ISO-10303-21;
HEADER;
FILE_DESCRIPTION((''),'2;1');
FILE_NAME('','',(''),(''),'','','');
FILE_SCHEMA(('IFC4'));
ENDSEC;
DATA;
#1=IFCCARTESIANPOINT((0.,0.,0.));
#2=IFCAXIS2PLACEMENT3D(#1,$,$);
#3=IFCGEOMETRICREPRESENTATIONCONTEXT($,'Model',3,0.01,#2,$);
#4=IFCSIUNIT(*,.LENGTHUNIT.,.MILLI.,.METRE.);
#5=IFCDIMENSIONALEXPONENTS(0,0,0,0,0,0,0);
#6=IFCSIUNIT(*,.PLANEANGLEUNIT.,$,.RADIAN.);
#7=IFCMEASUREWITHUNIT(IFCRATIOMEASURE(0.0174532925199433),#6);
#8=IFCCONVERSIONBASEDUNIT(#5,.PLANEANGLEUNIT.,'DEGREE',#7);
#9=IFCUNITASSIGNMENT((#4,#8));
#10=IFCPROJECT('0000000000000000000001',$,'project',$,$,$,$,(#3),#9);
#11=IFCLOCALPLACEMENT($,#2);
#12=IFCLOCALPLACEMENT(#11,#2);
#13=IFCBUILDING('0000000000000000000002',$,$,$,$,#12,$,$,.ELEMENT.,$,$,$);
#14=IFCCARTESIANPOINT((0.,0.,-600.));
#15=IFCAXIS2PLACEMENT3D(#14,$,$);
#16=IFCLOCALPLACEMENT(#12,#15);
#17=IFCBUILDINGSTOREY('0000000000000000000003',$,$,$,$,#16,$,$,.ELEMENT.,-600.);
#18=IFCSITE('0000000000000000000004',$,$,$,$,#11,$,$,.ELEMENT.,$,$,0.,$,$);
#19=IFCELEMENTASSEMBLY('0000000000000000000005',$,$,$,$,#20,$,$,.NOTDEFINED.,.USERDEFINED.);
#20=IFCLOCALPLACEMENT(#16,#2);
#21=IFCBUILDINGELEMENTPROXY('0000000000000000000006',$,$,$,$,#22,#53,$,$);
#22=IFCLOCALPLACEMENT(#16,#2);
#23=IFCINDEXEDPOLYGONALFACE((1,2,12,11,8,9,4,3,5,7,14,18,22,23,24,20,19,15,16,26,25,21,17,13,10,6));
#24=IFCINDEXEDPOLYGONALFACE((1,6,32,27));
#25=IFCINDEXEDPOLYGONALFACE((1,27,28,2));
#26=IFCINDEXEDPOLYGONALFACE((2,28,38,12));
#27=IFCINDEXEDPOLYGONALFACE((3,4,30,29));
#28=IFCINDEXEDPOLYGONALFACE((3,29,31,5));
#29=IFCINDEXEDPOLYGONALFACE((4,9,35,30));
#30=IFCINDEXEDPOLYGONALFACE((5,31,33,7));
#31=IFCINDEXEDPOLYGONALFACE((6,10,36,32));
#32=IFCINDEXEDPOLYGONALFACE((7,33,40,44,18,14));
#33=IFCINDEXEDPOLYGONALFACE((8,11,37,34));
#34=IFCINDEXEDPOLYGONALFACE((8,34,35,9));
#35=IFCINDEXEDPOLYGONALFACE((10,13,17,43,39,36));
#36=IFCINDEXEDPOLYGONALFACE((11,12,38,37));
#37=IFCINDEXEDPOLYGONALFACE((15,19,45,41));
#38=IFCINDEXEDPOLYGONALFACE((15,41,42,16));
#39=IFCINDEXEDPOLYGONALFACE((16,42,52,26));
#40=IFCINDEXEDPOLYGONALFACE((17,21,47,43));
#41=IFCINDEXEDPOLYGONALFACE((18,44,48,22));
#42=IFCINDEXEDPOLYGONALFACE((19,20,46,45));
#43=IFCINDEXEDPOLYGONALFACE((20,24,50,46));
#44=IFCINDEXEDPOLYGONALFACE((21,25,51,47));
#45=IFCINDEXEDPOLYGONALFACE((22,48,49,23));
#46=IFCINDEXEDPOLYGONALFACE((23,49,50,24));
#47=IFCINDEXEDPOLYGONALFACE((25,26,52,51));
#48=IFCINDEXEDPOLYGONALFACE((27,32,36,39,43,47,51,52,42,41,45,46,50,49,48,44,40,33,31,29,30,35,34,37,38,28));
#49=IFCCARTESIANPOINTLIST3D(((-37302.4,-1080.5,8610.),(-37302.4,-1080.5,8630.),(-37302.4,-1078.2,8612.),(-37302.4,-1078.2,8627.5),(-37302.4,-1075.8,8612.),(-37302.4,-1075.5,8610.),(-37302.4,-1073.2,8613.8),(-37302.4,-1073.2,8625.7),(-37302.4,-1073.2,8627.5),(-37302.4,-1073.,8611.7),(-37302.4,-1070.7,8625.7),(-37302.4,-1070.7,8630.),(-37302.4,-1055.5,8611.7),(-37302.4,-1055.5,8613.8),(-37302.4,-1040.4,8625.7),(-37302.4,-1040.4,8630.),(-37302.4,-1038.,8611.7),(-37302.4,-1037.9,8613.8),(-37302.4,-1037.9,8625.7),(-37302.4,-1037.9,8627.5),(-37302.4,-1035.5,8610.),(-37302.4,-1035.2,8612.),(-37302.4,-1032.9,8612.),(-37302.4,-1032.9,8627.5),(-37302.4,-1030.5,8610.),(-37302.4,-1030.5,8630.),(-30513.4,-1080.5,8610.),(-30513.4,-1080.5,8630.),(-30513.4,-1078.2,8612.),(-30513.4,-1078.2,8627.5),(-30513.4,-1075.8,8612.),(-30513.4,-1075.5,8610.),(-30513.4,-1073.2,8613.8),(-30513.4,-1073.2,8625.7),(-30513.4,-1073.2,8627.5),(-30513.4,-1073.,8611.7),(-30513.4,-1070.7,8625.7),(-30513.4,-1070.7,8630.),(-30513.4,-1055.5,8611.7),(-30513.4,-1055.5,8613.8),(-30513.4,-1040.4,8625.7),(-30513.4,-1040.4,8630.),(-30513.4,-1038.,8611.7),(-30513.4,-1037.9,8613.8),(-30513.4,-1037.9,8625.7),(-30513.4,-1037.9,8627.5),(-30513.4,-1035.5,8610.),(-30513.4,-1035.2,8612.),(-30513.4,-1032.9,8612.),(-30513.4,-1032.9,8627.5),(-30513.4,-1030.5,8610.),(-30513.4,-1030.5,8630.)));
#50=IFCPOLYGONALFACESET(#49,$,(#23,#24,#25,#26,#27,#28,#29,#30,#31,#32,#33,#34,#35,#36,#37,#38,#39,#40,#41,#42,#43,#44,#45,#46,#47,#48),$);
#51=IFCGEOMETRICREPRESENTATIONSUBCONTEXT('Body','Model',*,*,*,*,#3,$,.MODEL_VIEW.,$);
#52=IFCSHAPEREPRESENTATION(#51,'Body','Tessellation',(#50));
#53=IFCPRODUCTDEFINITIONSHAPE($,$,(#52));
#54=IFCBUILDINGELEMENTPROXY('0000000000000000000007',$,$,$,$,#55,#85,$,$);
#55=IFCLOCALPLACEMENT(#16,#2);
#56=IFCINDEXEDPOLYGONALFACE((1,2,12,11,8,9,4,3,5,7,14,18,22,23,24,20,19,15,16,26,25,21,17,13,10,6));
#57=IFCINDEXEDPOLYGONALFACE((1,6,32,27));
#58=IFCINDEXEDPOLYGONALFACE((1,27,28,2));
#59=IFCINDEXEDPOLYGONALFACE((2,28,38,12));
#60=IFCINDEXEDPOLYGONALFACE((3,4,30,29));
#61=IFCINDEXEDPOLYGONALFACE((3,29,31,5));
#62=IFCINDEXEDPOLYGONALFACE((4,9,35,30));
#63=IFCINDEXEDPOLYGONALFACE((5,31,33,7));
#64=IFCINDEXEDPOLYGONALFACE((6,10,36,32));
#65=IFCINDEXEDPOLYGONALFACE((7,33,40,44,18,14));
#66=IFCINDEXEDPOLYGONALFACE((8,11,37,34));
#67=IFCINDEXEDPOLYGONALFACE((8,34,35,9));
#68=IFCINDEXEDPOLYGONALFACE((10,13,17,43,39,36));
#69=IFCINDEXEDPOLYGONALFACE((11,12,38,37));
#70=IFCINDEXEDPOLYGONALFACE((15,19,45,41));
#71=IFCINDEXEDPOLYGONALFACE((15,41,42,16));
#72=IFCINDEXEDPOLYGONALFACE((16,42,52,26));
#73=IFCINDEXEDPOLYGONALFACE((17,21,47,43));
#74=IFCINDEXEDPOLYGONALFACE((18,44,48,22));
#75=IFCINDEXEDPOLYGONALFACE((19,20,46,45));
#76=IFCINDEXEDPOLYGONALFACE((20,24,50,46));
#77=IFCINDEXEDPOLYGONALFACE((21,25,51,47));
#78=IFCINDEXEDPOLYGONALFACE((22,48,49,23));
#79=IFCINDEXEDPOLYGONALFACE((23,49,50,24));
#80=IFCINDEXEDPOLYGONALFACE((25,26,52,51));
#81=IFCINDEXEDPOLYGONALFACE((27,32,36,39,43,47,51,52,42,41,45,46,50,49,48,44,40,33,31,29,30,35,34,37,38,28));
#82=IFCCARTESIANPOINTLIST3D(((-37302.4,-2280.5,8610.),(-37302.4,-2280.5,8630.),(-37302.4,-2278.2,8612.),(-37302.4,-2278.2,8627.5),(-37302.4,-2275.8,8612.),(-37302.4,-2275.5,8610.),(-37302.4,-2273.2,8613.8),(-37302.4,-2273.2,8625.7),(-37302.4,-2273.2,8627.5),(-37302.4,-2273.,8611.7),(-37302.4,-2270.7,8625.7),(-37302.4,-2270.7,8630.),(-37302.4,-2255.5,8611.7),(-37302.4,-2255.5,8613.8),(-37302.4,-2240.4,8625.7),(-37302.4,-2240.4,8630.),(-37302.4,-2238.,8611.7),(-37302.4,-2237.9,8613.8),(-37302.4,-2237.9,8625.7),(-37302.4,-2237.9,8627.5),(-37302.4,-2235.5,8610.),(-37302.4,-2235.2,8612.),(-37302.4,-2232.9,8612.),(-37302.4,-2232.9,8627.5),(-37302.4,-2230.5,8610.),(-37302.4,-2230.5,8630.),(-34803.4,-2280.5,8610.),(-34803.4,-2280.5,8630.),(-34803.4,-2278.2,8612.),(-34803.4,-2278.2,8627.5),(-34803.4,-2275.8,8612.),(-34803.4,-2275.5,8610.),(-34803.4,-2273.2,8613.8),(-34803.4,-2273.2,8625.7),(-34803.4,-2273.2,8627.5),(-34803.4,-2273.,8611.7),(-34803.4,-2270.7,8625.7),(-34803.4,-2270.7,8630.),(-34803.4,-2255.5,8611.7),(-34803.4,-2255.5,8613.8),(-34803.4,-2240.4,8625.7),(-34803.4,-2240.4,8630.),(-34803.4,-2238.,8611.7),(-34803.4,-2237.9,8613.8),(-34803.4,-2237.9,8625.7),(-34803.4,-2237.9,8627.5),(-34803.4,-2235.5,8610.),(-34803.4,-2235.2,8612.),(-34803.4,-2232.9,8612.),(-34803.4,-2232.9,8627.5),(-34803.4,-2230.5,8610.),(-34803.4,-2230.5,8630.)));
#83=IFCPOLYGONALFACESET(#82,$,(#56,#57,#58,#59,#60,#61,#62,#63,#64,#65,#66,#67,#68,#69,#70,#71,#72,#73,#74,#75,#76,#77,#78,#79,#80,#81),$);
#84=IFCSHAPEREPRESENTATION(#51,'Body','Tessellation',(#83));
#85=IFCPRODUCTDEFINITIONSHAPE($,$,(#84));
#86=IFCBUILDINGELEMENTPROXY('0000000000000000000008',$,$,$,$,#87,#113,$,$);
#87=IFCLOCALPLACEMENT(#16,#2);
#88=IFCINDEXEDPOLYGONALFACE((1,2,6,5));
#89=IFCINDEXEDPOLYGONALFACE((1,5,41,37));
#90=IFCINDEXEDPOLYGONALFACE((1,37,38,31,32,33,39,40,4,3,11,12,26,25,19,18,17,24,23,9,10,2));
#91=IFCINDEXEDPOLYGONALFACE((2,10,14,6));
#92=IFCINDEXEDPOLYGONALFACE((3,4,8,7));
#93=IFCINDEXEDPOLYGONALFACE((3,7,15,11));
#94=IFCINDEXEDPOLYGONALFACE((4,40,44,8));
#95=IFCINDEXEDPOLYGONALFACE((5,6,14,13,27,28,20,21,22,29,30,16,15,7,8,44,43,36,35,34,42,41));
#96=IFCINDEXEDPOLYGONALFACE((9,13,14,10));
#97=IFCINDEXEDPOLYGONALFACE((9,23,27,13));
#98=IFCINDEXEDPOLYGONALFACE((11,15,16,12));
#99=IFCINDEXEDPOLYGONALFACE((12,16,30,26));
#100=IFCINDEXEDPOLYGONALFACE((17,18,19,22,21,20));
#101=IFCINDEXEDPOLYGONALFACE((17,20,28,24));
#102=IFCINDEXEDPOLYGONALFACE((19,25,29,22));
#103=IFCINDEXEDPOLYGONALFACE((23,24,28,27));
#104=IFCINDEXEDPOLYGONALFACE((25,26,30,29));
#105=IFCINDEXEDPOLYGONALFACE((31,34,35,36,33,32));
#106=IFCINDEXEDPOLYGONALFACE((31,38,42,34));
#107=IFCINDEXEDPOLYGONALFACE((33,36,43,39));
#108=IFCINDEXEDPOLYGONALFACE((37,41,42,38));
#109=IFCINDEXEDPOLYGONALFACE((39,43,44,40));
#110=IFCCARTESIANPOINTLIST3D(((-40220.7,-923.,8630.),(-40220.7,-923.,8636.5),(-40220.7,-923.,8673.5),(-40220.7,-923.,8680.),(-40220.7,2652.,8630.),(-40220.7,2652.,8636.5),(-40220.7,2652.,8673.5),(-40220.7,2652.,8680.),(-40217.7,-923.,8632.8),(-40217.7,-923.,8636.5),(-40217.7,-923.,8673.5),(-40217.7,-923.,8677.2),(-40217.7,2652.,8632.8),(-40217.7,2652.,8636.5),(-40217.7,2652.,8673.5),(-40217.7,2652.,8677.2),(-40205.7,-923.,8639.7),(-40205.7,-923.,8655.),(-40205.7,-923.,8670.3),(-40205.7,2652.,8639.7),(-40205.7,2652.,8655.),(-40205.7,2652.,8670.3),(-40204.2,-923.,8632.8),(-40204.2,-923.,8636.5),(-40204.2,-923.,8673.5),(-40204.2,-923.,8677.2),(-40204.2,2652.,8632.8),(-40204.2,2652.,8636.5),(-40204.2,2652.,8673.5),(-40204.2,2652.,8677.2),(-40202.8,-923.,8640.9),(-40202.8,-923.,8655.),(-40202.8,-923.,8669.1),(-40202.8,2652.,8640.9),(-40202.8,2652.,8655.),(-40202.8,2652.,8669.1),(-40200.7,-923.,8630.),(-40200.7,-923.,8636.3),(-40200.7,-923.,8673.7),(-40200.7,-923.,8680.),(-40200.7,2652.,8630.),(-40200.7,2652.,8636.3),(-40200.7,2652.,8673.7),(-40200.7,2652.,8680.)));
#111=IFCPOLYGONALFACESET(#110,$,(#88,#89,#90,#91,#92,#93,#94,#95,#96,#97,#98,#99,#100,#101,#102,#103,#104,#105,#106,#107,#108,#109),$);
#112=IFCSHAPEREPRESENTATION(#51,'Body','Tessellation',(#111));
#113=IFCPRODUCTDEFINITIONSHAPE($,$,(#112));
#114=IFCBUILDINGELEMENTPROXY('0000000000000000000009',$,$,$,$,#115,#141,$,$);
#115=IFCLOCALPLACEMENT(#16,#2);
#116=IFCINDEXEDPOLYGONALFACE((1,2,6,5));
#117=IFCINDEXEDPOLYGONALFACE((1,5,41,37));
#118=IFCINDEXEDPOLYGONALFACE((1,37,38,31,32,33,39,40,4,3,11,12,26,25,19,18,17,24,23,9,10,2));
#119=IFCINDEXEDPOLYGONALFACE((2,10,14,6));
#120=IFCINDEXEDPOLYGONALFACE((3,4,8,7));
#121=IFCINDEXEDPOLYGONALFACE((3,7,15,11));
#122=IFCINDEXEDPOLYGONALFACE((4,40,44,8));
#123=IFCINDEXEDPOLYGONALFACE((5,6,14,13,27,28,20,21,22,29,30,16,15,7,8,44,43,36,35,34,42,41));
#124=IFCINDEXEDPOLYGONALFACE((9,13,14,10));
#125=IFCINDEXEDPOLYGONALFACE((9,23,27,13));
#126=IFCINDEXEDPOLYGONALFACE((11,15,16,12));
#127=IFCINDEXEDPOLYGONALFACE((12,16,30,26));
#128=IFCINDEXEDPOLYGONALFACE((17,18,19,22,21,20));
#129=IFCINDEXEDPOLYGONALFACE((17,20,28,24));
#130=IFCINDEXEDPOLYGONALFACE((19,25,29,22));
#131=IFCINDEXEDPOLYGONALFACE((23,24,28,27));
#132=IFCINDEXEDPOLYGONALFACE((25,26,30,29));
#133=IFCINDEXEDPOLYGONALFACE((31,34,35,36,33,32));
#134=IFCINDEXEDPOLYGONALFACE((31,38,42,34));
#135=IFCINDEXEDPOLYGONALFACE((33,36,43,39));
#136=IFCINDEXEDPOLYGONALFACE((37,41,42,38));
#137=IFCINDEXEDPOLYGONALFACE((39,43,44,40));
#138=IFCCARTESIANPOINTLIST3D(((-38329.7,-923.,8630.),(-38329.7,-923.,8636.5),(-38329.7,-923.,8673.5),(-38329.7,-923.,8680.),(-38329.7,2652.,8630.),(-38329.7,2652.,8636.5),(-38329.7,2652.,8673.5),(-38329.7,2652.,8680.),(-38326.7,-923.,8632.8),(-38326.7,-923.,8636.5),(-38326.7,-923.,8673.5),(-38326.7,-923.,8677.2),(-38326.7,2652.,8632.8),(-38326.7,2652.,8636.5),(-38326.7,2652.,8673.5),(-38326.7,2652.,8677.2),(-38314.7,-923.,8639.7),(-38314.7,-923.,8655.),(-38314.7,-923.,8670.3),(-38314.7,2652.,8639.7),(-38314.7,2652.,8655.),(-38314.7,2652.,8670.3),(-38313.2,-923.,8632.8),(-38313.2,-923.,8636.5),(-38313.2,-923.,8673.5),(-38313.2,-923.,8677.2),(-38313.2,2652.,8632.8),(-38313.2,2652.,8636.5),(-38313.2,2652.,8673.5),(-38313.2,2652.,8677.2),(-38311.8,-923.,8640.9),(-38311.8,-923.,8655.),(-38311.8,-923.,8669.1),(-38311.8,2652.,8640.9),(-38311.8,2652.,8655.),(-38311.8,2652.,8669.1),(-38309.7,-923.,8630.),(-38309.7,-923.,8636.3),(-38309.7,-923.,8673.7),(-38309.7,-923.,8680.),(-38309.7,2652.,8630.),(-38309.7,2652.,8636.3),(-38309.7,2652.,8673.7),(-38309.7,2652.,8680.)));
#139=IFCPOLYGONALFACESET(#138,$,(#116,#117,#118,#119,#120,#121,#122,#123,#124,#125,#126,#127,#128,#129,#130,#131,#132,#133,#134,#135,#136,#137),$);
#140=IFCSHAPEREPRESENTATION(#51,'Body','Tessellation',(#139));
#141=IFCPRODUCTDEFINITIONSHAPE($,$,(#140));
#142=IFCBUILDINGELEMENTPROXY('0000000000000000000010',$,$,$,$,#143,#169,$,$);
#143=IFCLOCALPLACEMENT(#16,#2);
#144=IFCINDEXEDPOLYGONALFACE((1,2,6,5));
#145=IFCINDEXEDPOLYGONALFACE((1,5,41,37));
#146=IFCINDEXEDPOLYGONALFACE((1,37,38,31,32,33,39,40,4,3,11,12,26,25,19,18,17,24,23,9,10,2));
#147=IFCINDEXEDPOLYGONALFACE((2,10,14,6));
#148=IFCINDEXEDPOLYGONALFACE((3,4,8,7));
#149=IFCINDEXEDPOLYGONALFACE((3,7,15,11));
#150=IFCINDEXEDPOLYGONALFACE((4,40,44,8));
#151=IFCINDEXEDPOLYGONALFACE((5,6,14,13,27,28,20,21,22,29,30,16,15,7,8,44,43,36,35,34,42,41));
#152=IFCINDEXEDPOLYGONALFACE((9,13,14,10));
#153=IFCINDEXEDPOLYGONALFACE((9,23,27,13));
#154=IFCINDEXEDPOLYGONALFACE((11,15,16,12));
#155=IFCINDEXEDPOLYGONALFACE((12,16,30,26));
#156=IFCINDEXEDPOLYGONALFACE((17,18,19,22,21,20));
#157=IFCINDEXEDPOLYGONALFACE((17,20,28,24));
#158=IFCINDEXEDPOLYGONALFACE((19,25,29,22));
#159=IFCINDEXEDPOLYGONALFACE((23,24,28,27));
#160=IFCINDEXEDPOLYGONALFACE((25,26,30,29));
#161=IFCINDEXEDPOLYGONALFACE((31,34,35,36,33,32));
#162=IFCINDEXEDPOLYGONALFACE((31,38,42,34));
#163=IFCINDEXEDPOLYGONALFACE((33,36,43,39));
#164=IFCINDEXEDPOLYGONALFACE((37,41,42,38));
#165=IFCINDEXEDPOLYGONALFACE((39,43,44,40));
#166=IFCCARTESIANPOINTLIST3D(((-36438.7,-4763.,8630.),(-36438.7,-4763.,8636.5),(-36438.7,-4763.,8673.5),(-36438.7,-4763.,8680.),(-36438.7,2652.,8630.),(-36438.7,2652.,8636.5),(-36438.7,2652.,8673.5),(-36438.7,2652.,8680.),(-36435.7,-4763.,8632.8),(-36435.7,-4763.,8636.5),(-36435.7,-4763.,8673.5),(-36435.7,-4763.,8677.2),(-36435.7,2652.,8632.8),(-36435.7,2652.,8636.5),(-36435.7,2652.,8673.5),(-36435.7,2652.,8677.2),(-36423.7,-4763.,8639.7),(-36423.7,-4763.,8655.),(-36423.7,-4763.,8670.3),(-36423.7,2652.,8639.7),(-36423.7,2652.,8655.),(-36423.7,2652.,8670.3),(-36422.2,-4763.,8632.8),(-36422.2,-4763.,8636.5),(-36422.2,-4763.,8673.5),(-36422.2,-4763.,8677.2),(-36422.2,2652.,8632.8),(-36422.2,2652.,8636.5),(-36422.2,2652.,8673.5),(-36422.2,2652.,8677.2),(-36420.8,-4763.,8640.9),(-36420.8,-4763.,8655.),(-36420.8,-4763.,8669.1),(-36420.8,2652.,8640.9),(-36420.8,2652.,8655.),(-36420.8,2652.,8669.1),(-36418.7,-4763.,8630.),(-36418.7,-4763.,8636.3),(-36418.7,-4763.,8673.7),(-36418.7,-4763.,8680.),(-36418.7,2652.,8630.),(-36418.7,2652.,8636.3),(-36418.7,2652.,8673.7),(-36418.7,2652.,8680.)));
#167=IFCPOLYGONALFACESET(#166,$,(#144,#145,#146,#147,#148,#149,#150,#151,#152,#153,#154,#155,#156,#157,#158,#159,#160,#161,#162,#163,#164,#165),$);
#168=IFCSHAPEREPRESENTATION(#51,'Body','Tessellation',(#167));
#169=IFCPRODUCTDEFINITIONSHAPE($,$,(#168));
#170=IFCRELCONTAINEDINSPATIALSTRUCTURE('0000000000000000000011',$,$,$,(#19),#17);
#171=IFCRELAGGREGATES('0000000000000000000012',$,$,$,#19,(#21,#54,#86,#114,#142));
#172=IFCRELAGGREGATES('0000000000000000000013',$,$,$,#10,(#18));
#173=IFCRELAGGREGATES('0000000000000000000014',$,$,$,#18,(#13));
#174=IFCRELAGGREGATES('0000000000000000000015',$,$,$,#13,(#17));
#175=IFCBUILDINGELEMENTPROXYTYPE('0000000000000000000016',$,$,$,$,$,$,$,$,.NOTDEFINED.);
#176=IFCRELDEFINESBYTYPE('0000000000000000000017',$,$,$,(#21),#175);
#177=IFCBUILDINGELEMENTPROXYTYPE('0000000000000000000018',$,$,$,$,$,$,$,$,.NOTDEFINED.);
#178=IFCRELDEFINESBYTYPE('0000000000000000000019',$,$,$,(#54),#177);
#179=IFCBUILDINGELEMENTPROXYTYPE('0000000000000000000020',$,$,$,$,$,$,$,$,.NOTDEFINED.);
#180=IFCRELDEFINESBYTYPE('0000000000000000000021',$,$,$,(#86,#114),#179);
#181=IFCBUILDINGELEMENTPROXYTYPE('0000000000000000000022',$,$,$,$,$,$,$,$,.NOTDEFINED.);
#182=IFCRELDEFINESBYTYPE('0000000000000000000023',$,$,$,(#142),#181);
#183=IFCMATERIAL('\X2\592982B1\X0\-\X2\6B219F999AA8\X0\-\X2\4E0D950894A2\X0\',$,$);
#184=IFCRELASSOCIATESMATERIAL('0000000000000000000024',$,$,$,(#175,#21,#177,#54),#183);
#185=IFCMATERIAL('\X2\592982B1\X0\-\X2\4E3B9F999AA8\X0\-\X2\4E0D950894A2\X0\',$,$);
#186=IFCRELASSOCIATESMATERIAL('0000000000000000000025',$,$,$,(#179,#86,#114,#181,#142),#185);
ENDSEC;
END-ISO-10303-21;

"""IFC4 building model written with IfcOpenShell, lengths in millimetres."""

from ifc_helpers import new_model, entity, si_unit, converted_unit, frame, origin, place, context, subcontext, project, spatial, polyline, outline, extrude, source, transform, mapped, material, type_object, type_shapes, element, aggregate, save


model = new_model("IFC4")

# Units and contexts
model_context = context("Model", 3, precision=0.01, world=origin())
body_context = subcontext(model_context, "Body", "Model", "MODEL_VIEW")
ifc_project = project(units=[si_unit("LENGTHUNIT", "METRE", prefix="MILLI"), converted_unit("PLANEANGLEUNIT", "DEGREE", entity("IfcRatioMeasure", 0.0174532925199433), si_unit("PLANEANGLEUNIT", "RADIAN"), dimensions=[0, 0, 0, 0, 0, 0, 0])], contexts=[model_context])

# Site, building, storey
site_placement = place(None, origin())
site = spatial("IfcSite", under=ifc_project, at=site_placement, CompositionType="ELEMENT", RefElevation=0.0)
building_placement = place(site_placement, origin())
building = spatial("IfcBuilding", under=site, at=building_placement, CompositionType="ELEMENT")
storey_placement = place(building_placement, frame((0.0, 0.0, -600.0)))
storey = spatial("IfcBuildingStorey", under=building, at=storey_placement, CompositionType="ELEMENT", Elevation=-600.0)

# Element assembly
assembly_1_placement = place(storey_placement, origin())
assembly_1 = element("IfcElementAssembly", 1, at=assembly_1_placement, inside=storey, AssemblyPlace="NOTDEFINED", PredefinedType="USERDEFINED")

# Building element proxies
ifc_material_1 = material(Name="天花-次龙骨-不锈钢")
building_element_proxy_type_1 = type_object("IfcBuildingElementProxyType", PredefinedType="NOTDEFINED", material=ifc_material_1)
shared_shape_1 = source(origin(), body_context, "Body", "SweptSolid", [
    extrude(outline(polyline([(-25.0, -9.1), (-20.0, -9.1), (-17.5, -7.4), (0.0, -7.4), (17.5, -7.4), (20.0, -9.1), (25.0, -9.1), (25.0, 10.9), (15.1, 10.9), (15.1, 6.6), (17.6, 6.6), (17.6, 8.4), (22.6, 8.4), (22.6, -7.1), (20.3, -7.1), (17.6, -5.3), (0.0, -5.3), (-17.6, -5.3), (-20.3, -7.1), (-22.6, -7.1), (-22.6, 8.4), (-17.6, 8.4), (-17.6, 6.6), (-15.1, 6.6), (-15.1, 10.9), (-25.0, 10.9), (-25.0, -9.1)])), frame((0.0, 0.0, -0.9), z_axis=(1.0, 0.0, 0.0), x_axis=(0.0, 1.0, 0.0)), (0.0, 0.0, 1.0), 6789.0),
])
type_shapes(building_element_proxy_type_1, [shared_shape_1])
proxy_1_placement = place(assembly_1_placement, frame((-37302.4, -1055.5, 8620.0)))
proxy_1 = element("IfcBuildingElementProxy", 2, at=proxy_1_placement, type_object=building_element_proxy_type_1, material=ifc_material_1, context=body_context, shape_type="MappedRepresentation", body=[
    mapped(shared_shape_1, transform((0.0, 0.0, 0.0), scale=1.0)),
])
building_element_proxy_type_2 = type_object("IfcBuildingElementProxyType", PredefinedType="NOTDEFINED", material=ifc_material_1)
shared_shape_2 = source(origin(), body_context, "Body", "SweptSolid", [
    extrude(outline(polyline([(-25.0, -9.1), (-20.0, -9.1), (-17.5, -7.4), (0.0, -7.4), (17.5, -7.4), (20.0, -9.1), (25.0, -9.1), (25.0, 10.9), (15.1, 10.9), (15.1, 6.6), (17.6, 6.6), (17.6, 8.4), (22.6, 8.4), (22.6, -7.1), (20.3, -7.1), (17.6, -5.3), (0.0, -5.3), (-17.6, -5.3), (-20.3, -7.1), (-22.6, -7.1), (-22.6, 8.4), (-17.6, 8.4), (-17.6, 6.6), (-15.1, 6.6), (-15.1, 10.9), (-25.0, 10.9), (-25.0, -9.1)])), frame((0.0, 0.0, -0.9), z_axis=(1.0, 0.0, 0.0), x_axis=(0.0, 1.0, 0.0)), (0.0, 0.0, 1.0), 2499.0),
])
type_shapes(building_element_proxy_type_2, [shared_shape_2])
proxy_2_placement = place(assembly_1_placement, frame((-37302.4, -2255.5, 8620.0)))
proxy_2 = element("IfcBuildingElementProxy", 3, at=proxy_2_placement, type_object=building_element_proxy_type_2, material=ifc_material_1, context=body_context, shape_type="MappedRepresentation", body=[
    mapped(shared_shape_2, transform((0.0, 0.0, 0.0), scale=1.0)),
])
ifc_material_2 = material(Name="天花-主龙骨-不锈钢")
building_element_proxy_type_3 = type_object("IfcBuildingElementProxyType", PredefinedType="NOTDEFINED", material=ifc_material_2)
shared_shape_3 = source(origin(), body_context, "Body", "SweptSolid", [
    extrude(outline(polyline([(-25.0, -11.7), (-18.5, -11.7), (-18.5, -8.7), (-22.2, -8.7), (-22.2, 4.8), (-18.5, 4.8), (-15.3, 3.3), (0.0, 3.3), (15.3, 3.3), (18.5, 4.8), (22.2, 4.8), (22.2, -8.7), (18.5, -8.7), (18.5, -11.7), (25.0, -11.7), (25.0, 8.3), (18.7, 8.3), (14.1, 6.2), (0.0, 6.2), (-14.1, 6.2), (-18.7, 8.3), (-25.0, 8.3), (-25.0, -11.7)])), frame((0.0, 1.7, 0.0), z_axis=(1.0, 0.0, 0.0), x_axis=(0.0, 0.0, -1.0)), (0.0, 0.0, 1.0), 3575.0),
])
type_shapes(building_element_proxy_type_3, [shared_shape_3])
proxy_3_placement = place(assembly_1_placement, frame((-40210.7, 2652.0, 8655.0), z_axis=(0.0, 0.0, 1.0), x_axis=(0.0, -1.0, 0.0)))
proxy_3 = element("IfcBuildingElementProxy", 4, at=proxy_3_placement, type_object=building_element_proxy_type_3, material=ifc_material_2, context=body_context, shape_type="MappedRepresentation", body=[
    mapped(shared_shape_3, transform((0.0, 0.0, 0.0), scale=1.0)),
])
proxy_4_placement = place(assembly_1_placement, frame((-38319.7, 2652.0, 8655.0), z_axis=(0.0, 0.0, 1.0), x_axis=(0.0, -1.0, 0.0)))
proxy_4 = element("IfcBuildingElementProxy", 5, at=proxy_4_placement, type_object=building_element_proxy_type_3, material=ifc_material_2, context=body_context, shape_type="MappedRepresentation", body=[
    mapped(shared_shape_3, transform((0.0, 0.0, 0.0), scale=1.0)),
])
building_element_proxy_type_4 = type_object("IfcBuildingElementProxyType", PredefinedType="NOTDEFINED", material=ifc_material_2)
shared_shape_4 = source(origin(), body_context, "Body", "SweptSolid", [
    extrude(outline(polyline([(-25.0, -11.7), (-18.5, -11.7), (-18.5, -8.7), (-22.2, -8.7), (-22.2, 4.8), (-18.5, 4.8), (-15.3, 3.3), (0.0, 3.3), (15.3, 3.3), (18.5, 4.8), (22.2, 4.8), (22.2, -8.7), (18.5, -8.7), (18.5, -11.7), (25.0, -11.7), (25.0, 8.3), (18.7, 8.3), (14.1, 6.2), (0.0, 6.2), (-14.1, 6.2), (-18.7, 8.3), (-25.0, 8.3), (-25.0, -11.7)])), frame((0.0, 1.7, 0.0), z_axis=(1.0, 0.0, 0.0), x_axis=(0.0, 0.0, -1.0)), (0.0, 0.0, 1.0), 7415.0),
])
type_shapes(building_element_proxy_type_4, [shared_shape_4])
proxy_5_placement = place(assembly_1_placement, frame((-36428.7, 2652.0, 8655.0), z_axis=(0.0, 0.0, 1.0), x_axis=(0.0, -1.0, 0.0)))
proxy_5 = element("IfcBuildingElementProxy", 6, at=proxy_5_placement, type_object=building_element_proxy_type_4, material=ifc_material_2, context=body_context, shape_type="MappedRepresentation", body=[
    mapped(shared_shape_4, transform((0.0, 0.0, 0.0), scale=1.0)),
])
aggregate(assembly_1, [proxy_1, proxy_2, proxy_3, proxy_4, proxy_5])

save(model, "model.ifc")
